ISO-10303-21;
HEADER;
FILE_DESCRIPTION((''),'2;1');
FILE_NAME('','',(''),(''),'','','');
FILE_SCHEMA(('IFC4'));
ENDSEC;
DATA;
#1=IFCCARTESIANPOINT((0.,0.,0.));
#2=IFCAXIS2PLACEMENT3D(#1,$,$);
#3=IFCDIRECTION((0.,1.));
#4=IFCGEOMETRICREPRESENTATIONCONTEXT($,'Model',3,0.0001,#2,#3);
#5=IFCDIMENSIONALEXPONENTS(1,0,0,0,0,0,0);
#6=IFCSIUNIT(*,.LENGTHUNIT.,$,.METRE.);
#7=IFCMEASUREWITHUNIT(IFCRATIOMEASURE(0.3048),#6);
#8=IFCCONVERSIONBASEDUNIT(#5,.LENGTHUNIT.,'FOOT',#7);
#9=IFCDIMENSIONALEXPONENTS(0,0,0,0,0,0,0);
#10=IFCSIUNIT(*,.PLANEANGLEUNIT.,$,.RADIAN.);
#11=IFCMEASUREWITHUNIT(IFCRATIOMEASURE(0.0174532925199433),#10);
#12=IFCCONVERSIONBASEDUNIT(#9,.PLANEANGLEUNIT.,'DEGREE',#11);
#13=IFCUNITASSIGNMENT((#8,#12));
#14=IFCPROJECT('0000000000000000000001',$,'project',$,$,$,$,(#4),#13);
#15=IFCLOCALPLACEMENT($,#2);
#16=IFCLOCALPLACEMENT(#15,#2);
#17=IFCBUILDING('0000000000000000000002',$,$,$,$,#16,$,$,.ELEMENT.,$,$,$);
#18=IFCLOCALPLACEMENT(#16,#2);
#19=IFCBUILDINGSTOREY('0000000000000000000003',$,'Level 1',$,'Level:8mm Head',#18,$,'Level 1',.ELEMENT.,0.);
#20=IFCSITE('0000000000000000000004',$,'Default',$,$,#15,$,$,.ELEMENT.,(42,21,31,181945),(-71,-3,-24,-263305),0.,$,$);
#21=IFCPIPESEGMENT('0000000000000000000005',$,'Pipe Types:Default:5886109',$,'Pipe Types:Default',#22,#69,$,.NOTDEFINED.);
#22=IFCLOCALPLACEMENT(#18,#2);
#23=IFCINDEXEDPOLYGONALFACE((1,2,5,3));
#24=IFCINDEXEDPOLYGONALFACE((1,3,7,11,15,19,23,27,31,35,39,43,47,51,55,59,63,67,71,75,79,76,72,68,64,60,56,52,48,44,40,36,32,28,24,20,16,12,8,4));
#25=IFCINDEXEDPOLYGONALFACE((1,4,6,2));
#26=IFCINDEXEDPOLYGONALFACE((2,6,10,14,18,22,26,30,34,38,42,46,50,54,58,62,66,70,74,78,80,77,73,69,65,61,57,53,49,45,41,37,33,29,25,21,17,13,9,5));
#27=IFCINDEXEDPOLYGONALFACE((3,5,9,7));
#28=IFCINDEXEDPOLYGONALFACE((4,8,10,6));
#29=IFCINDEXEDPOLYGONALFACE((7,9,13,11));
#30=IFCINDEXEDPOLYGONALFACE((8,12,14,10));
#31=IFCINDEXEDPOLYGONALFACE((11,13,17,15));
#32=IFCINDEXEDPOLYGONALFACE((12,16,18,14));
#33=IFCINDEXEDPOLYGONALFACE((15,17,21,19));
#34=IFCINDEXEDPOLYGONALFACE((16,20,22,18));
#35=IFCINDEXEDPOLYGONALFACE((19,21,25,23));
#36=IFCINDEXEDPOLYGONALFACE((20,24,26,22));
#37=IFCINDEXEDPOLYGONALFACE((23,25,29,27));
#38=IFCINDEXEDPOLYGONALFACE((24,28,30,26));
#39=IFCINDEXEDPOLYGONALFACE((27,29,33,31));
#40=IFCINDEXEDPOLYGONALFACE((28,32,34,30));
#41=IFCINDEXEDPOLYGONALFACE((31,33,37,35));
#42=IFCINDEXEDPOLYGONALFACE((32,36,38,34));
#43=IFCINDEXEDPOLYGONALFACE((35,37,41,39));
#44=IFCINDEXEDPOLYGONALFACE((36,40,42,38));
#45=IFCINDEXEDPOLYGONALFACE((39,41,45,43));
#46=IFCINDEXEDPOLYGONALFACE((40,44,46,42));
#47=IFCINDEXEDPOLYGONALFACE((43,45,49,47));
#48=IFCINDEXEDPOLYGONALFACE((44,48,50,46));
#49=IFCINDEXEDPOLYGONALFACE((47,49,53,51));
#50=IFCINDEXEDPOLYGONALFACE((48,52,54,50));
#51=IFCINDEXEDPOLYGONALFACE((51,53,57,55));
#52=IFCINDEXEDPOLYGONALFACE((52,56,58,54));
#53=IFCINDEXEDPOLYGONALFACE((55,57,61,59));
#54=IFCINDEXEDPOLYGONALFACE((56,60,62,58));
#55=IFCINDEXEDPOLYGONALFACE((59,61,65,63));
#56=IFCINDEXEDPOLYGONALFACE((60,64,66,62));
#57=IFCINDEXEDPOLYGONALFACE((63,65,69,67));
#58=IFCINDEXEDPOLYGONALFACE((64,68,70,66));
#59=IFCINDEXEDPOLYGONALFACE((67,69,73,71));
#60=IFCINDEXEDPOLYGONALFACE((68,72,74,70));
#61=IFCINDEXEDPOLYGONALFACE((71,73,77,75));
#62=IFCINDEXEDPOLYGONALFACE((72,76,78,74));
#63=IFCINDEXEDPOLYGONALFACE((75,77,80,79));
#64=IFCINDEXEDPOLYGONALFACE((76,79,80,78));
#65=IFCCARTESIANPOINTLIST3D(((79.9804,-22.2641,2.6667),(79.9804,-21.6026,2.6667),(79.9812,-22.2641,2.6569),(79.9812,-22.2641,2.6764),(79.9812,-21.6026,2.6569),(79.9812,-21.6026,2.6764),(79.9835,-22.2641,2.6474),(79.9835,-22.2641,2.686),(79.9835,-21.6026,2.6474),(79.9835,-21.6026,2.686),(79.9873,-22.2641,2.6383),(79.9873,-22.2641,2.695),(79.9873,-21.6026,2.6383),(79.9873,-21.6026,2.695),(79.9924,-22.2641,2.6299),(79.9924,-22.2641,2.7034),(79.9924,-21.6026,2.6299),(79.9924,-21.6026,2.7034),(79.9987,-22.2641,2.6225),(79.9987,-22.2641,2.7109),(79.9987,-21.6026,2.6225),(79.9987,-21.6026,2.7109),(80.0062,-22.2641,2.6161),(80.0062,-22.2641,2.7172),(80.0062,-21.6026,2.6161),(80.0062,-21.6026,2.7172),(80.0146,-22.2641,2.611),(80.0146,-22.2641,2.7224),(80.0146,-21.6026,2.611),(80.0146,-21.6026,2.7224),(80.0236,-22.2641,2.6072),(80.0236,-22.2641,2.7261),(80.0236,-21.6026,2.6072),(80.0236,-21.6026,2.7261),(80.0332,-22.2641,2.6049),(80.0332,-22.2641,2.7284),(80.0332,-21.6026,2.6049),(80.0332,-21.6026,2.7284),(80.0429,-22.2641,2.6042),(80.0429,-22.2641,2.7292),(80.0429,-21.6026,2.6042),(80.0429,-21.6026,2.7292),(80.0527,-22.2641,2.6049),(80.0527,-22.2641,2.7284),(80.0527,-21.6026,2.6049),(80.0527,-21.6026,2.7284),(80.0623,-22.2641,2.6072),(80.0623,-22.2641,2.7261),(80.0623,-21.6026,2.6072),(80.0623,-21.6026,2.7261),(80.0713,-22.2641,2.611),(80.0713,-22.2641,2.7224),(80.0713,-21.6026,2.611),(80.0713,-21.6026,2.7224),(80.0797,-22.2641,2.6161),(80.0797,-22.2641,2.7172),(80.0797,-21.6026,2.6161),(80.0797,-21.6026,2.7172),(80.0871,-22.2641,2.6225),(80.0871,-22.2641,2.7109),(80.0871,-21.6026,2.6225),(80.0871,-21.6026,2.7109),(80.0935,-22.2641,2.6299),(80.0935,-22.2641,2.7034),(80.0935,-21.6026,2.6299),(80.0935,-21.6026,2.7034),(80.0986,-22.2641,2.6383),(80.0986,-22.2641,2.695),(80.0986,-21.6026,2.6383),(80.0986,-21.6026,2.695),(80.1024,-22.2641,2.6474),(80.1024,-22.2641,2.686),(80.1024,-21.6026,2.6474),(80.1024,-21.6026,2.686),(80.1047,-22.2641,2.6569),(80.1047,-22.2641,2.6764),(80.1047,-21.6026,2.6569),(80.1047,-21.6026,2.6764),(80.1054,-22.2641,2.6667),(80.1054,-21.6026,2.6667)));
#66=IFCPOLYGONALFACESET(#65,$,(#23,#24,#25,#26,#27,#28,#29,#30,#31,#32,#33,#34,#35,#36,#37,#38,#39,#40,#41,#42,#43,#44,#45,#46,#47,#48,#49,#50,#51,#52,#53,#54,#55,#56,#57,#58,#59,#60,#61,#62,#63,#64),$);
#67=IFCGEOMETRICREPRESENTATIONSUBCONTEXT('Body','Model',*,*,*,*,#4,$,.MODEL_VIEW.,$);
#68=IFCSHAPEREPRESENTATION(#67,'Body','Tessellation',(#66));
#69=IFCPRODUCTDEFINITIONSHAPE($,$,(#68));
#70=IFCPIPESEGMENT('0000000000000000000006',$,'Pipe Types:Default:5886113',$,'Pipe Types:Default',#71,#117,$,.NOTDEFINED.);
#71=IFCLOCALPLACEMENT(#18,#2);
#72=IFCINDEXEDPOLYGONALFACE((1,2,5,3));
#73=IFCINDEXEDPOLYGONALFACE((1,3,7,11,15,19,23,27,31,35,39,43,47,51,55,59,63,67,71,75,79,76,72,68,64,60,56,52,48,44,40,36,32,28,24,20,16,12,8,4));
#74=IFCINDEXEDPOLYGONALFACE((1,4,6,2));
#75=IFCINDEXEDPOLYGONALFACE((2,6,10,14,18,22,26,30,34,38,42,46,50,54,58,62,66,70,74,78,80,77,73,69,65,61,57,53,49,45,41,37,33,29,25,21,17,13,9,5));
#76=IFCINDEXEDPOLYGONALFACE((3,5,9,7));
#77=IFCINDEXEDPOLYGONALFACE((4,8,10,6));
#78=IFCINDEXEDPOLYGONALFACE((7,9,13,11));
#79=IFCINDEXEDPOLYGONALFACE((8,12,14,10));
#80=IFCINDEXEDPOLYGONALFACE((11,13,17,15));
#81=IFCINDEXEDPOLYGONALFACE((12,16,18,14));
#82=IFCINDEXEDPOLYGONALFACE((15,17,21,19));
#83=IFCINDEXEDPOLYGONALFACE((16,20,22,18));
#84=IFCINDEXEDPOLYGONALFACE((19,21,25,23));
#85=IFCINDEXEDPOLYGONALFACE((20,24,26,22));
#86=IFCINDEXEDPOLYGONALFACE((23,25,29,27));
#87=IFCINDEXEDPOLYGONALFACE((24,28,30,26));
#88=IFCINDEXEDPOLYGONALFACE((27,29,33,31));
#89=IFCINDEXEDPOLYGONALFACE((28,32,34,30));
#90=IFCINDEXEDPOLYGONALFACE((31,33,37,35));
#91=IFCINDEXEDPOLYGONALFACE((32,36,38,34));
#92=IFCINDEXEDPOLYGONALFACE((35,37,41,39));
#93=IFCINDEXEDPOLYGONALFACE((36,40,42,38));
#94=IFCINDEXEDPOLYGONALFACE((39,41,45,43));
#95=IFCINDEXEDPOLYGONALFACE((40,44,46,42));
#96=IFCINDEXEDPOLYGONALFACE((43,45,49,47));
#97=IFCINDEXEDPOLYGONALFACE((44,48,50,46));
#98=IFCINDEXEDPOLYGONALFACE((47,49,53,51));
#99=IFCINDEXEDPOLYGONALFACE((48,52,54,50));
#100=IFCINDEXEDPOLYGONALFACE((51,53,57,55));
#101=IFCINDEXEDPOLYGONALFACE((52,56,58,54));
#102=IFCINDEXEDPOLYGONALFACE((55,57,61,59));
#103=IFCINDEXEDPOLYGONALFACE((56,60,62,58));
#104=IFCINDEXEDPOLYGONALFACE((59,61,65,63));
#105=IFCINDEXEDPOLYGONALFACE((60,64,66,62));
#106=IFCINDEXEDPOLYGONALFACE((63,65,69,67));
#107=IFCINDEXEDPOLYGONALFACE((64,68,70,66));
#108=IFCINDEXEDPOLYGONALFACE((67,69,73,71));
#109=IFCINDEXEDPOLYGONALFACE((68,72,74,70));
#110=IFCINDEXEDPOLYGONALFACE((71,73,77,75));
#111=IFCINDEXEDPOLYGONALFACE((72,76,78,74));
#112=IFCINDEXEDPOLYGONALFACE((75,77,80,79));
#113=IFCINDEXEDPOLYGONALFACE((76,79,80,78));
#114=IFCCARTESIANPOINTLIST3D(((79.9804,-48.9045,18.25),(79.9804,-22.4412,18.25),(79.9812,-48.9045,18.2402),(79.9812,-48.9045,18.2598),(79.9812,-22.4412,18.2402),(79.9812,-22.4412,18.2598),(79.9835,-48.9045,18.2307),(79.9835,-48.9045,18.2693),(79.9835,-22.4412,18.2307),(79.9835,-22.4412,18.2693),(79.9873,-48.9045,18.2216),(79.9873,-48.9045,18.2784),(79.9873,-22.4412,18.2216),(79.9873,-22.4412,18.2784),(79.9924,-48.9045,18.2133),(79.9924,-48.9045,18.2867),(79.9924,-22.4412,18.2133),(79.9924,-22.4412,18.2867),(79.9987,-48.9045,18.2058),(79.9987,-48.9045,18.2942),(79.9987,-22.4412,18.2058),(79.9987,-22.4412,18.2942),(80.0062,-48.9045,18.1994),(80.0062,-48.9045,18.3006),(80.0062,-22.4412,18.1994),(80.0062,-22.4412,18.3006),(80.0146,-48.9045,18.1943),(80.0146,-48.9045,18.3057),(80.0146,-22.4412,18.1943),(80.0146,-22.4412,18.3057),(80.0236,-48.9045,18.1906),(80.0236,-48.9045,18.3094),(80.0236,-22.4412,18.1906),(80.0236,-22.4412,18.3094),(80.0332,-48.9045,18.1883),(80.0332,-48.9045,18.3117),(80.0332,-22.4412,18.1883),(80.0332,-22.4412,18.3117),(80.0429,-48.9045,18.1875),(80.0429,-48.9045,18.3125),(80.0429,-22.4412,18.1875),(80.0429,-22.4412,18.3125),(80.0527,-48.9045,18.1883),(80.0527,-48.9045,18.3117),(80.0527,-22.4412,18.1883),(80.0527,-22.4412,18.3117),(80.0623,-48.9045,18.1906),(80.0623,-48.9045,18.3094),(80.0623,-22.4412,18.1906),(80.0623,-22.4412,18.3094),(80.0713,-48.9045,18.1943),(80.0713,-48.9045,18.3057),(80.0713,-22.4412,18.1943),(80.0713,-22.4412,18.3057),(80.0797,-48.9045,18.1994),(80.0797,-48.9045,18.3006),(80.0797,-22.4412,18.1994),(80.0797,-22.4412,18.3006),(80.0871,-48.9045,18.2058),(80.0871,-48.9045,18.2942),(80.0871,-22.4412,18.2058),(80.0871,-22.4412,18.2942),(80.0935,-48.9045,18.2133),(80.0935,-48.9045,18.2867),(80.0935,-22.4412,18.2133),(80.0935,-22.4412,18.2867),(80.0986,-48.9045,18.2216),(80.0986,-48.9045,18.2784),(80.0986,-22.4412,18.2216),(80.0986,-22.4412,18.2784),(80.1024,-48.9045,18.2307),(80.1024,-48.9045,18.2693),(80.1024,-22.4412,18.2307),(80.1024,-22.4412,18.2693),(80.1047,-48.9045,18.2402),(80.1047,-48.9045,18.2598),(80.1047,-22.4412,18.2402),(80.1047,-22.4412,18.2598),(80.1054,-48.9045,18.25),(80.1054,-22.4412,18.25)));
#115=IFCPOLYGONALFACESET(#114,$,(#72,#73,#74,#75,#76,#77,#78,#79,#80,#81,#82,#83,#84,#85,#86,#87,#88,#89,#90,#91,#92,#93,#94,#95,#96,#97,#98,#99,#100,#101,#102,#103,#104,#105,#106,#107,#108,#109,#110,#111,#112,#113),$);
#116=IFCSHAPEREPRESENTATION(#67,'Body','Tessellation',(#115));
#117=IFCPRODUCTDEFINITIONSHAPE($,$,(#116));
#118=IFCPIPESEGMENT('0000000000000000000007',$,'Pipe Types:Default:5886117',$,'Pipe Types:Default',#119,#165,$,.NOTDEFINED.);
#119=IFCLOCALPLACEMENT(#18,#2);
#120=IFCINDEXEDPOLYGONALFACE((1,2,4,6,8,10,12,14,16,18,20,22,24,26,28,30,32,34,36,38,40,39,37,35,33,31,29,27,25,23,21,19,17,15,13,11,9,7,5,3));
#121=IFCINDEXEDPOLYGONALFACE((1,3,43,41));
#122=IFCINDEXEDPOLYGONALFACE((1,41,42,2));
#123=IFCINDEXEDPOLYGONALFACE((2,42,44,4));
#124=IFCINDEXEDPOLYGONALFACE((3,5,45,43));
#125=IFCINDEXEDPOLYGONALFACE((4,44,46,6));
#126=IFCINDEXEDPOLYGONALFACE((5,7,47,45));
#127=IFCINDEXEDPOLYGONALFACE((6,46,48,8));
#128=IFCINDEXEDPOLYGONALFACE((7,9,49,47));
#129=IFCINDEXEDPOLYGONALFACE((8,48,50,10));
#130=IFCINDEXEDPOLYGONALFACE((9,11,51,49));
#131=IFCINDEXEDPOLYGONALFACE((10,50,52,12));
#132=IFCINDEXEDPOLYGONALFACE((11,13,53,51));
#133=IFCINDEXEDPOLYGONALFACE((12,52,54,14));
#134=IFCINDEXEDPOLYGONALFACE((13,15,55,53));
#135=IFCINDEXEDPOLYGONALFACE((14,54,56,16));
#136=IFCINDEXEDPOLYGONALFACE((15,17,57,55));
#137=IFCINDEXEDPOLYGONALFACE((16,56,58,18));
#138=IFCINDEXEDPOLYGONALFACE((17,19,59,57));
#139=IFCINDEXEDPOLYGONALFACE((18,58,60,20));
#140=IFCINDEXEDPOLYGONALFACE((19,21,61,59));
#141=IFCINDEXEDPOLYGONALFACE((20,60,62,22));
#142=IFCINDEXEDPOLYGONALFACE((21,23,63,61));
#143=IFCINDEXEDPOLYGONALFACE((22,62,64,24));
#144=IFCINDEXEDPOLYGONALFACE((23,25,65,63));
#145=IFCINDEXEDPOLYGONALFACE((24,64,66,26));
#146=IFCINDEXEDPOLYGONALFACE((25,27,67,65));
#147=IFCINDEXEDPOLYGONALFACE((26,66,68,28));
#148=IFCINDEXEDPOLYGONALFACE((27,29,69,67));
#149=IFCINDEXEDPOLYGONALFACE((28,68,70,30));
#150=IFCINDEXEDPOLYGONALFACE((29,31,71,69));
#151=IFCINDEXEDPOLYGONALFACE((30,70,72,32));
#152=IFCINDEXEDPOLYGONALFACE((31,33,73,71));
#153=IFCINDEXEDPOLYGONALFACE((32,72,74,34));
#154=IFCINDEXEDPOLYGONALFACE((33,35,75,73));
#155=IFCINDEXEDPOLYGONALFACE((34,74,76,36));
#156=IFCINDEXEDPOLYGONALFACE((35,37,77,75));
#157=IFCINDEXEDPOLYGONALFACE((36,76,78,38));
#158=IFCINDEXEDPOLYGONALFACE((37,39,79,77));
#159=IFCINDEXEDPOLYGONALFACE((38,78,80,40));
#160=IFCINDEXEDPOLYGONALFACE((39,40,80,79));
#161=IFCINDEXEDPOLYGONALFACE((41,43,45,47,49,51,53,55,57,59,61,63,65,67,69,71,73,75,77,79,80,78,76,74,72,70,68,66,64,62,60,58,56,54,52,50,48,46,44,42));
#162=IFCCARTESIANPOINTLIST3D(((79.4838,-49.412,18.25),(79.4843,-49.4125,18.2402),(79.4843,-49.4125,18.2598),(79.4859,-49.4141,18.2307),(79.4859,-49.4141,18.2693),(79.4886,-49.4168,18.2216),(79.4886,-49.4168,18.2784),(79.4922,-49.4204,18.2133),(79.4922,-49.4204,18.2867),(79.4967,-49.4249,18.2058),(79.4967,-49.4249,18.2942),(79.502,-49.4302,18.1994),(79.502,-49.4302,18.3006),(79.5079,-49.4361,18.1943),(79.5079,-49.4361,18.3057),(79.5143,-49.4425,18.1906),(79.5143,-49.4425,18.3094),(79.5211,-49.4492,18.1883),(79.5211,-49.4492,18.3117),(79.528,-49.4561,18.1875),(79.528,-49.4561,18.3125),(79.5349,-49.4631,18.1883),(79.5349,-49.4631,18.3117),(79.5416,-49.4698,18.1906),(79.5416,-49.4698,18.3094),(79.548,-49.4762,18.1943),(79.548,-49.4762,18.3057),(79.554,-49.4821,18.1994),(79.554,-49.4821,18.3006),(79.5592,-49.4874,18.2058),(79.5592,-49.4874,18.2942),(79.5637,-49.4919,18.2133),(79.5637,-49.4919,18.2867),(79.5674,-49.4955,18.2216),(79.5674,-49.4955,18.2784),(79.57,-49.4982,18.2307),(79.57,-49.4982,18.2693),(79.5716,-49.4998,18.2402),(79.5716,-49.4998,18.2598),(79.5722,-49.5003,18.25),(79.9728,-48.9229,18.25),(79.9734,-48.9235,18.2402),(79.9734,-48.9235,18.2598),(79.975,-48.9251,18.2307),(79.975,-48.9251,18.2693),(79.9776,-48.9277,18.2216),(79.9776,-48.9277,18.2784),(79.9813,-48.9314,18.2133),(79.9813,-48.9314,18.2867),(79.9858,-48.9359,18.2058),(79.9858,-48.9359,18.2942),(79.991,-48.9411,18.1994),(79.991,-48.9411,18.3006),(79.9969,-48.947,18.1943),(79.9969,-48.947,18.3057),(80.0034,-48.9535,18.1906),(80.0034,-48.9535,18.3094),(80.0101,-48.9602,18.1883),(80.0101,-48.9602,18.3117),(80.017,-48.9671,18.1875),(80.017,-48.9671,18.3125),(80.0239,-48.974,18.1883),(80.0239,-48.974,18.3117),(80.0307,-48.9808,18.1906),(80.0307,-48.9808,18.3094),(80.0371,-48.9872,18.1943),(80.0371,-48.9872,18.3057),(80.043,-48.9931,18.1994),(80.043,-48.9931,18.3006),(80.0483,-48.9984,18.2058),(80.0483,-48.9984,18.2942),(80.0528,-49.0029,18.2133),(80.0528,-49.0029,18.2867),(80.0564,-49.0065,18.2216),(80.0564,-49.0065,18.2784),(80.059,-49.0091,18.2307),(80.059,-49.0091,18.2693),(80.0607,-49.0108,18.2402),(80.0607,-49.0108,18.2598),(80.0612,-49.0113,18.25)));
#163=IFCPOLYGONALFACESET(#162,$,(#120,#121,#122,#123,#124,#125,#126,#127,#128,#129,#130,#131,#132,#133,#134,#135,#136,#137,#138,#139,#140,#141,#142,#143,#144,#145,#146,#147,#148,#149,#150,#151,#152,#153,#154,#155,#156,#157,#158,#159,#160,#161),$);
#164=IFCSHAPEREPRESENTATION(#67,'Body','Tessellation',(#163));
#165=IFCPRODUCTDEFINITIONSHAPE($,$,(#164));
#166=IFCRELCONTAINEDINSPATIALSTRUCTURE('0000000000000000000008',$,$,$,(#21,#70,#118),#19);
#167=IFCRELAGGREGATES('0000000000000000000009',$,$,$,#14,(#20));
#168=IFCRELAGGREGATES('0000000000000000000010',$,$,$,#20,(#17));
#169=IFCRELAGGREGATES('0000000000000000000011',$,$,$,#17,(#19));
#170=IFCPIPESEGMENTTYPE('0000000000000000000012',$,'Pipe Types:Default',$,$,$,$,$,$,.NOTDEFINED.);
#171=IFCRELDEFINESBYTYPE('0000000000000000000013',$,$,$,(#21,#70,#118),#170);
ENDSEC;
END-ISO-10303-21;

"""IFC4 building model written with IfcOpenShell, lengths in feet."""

from ifc_helpers import new_model, entity, si_unit, converted_unit, direction, frame, origin, place, context, subcontext, project, spatial, indexed_curve, outline, extrude, type_object, element, save


model = new_model("IFC4")

# Units and contexts
model_context = context("Model", 3, precision=0.0001, world=origin(), true_north=direction((0.0, 1.0)))
body_context = subcontext(model_context, "Body", "Model", "MODEL_VIEW")
ifc_project = project(units=[converted_unit("LENGTHUNIT", "FOOT", entity("IfcRatioMeasure", 0.3048), si_unit("LENGTHUNIT", "METRE"), dimensions=[1, 0, 0, 0, 0, 0, 0]), converted_unit("PLANEANGLEUNIT", "DEGREE", entity("IfcRatioMeasure", 0.0174532925199433), si_unit("PLANEANGLEUNIT", "RADIAN"), dimensions=[0, 0, 0, 0, 0, 0, 0])], contexts=[model_context])

# Site, building, storey
site_placement = place(None, origin())
site = spatial("IfcSite", under=ifc_project, at=site_placement, Name="Default", CompositionType="ELEMENT", RefLatitude=(42, 21, 31, 181945), RefLongitude=(-71, -3, -24, -263305), RefElevation=0.0)
building_placement = place(site_placement, origin())
building = spatial("IfcBuilding", under=site, at=building_placement, CompositionType="ELEMENT")
storey_placement = place(building_placement, origin())
storey = spatial("IfcBuildingStorey", under=building, at=storey_placement, Name="Level 1", ObjectType="Level:8mm Head", LongName="Level 1", CompositionType="ELEMENT", Elevation=0.0)

# Pipe segments
pipe_segment_type = type_object("IfcPipeSegmentType", Name="Pipe Types:Default", PredefinedType="NOTDEFINED")
pipe_segment_1_placement = place(storey_placement, origin())
element("IfcPipeSegment", 1, at=pipe_segment_1_placement, inside=storey, type_object=pipe_segment_type, Name="Pipe Types:Default:5886109", ObjectType="Pipe Types:Default", PredefinedType="NOTDEFINED", context=body_context, shape_type="SweptSolid", body=[
    extrude(outline(indexed_curve([(0.0625, 0.0), (0.0617, 0.0098), (0.0594, 0.0193), (0.0557, 0.0284), (0.0506, 0.0367), (0.0442, 0.0442), (0.0367, 0.0506), (0.0284, 0.0557), (0.0193, 0.0594), (0.0098, 0.0617), (0.0, 0.0625), (-0.0098, 0.0617), (-0.0193, 0.0594), (-0.0284, 0.0557), (-0.0367, 0.0506), (-0.0442, 0.0442), (-0.0506, 0.0367), (-0.0557, 0.0284), (-0.0594, 0.0193), (-0.0617, 0.0098), (-0.0625, 0.0), (-0.0617, -0.0098), (-0.0594, -0.0193), (-0.0557, -0.0284), (-0.0506, -0.0367), (-0.0442, -0.0442), (-0.0367, -0.0506), (-0.0284, -0.0557), (-0.0193, -0.0594), (-0.0098, -0.0617), (0.0, -0.0625), (0.0098, -0.0617), (0.0193, -0.0594), (0.0284, -0.0557), (0.0367, -0.0506), (0.0442, -0.0442), (0.0506, -0.0367), (0.0557, -0.0284), (0.0594, -0.0193), (0.0617, -0.0098), (0.0625, 0.0)], self_intersect=False)), frame((80.0429, -22.2641, 2.6667), z_axis=(0.0, 1.0, 0.0), x_axis=(1.0, 0.0, 0.0)), (0.0, 0.0, 1.0), 0.6615),
])
pipe_segment_2_placement = place(storey_placement, origin())
element("IfcPipeSegment", 2, at=pipe_segment_2_placement, inside=storey, type_object=pipe_segment_type, Name="Pipe Types:Default:5886113", ObjectType="Pipe Types:Default", PredefinedType="NOTDEFINED", context=body_context, shape_type="SweptSolid", body=[
    extrude(outline(indexed_curve([(0.0625, 0.0), (0.0617, 0.0098), (0.0594, 0.0193), (0.0557, 0.0284), (0.0506, 0.0367), (0.0442, 0.0442), (0.0367, 0.0506), (0.0284, 0.0557), (0.0193, 0.0594), (0.0098, 0.0617), (0.0, 0.0625), (-0.0098, 0.0617), (-0.0193, 0.0594), (-0.0284, 0.0557), (-0.0367, 0.0506), (-0.0442, 0.0442), (-0.0506, 0.0367), (-0.0557, 0.0284), (-0.0594, 0.0193), (-0.0617, 0.0098), (-0.0625, 0.0), (-0.0617, -0.0098), (-0.0594, -0.0193), (-0.0557, -0.0284), (-0.0506, -0.0367), (-0.0442, -0.0442), (-0.0367, -0.0506), (-0.0284, -0.0557), (-0.0193, -0.0594), (-0.0098, -0.0617), (0.0, -0.0625), (0.0098, -0.0617), (0.0193, -0.0594), (0.0284, -0.0557), (0.0367, -0.0506), (0.0442, -0.0442), (0.0506, -0.0367), (0.0557, -0.0284), (0.0594, -0.0193), (0.0617, -0.0098), (0.0625, 0.0)], self_intersect=False)), frame((80.0429, -48.9045, 18.25), z_axis=(0.0, 1.0, 0.0), x_axis=(-1.0, 0.0, 0.0)), (0.0, 0.0, 1.0), 26.4633),
])
pipe_segment_3_placement = place(storey_placement, origin())
element("IfcPipeSegment", 3, at=pipe_segment_3_placement, inside=storey, type_object=pipe_segment_type, Name="Pipe Types:Default:5886117", ObjectType="Pipe Types:Default", PredefinedType="NOTDEFINED", context=body_context, shape_type="SweptSolid", body=[
    extrude(outline(indexed_curve([(0.0625, 0.0), (0.0617, 0.0098), (0.0594, 0.0193), (0.0557, 0.0284), (0.0506, 0.0367), (0.0442, 0.0442), (0.0367, 0.0506), (0.0284, 0.0557), (0.0193, 0.0594), (0.0098, 0.0617), (0.0, 0.0625), (-0.0098, 0.0617), (-0.0193, 0.0594), (-0.0284, 0.0557), (-0.0367, 0.0506), (-0.0442, 0.0442), (-0.0506, 0.0367), (-0.0557, 0.0284), (-0.0594, 0.0193), (-0.0617, 0.0098), (-0.0625, 0.0), (-0.0617, -0.0098), (-0.0594, -0.0193), (-0.0557, -0.0284), (-0.0506, -0.0367), (-0.0442, -0.0442), (-0.0367, -0.0506), (-0.0284, -0.0557), (-0.0193, -0.0594), (-0.0098, -0.0617), (0.0, -0.0625), (0.0098, -0.0617), (0.0193, -0.0594), (0.0284, -0.0557), (0.0367, -0.0506), (0.0442, -0.0442), (0.0506, -0.0367), (0.0557, -0.0284), (0.0594, -0.0193), (0.0617, -0.0098), (0.0625, 0.0)], self_intersect=False)), frame((79.528, -49.4561, 18.25), z_axis=(0.707107, 0.707107, 0.0), x_axis=(-0.707107, 0.707107, 0.0)), (0.0, 0.0, 1.0), 0.6916),
])

save(model, "model.ifc")
